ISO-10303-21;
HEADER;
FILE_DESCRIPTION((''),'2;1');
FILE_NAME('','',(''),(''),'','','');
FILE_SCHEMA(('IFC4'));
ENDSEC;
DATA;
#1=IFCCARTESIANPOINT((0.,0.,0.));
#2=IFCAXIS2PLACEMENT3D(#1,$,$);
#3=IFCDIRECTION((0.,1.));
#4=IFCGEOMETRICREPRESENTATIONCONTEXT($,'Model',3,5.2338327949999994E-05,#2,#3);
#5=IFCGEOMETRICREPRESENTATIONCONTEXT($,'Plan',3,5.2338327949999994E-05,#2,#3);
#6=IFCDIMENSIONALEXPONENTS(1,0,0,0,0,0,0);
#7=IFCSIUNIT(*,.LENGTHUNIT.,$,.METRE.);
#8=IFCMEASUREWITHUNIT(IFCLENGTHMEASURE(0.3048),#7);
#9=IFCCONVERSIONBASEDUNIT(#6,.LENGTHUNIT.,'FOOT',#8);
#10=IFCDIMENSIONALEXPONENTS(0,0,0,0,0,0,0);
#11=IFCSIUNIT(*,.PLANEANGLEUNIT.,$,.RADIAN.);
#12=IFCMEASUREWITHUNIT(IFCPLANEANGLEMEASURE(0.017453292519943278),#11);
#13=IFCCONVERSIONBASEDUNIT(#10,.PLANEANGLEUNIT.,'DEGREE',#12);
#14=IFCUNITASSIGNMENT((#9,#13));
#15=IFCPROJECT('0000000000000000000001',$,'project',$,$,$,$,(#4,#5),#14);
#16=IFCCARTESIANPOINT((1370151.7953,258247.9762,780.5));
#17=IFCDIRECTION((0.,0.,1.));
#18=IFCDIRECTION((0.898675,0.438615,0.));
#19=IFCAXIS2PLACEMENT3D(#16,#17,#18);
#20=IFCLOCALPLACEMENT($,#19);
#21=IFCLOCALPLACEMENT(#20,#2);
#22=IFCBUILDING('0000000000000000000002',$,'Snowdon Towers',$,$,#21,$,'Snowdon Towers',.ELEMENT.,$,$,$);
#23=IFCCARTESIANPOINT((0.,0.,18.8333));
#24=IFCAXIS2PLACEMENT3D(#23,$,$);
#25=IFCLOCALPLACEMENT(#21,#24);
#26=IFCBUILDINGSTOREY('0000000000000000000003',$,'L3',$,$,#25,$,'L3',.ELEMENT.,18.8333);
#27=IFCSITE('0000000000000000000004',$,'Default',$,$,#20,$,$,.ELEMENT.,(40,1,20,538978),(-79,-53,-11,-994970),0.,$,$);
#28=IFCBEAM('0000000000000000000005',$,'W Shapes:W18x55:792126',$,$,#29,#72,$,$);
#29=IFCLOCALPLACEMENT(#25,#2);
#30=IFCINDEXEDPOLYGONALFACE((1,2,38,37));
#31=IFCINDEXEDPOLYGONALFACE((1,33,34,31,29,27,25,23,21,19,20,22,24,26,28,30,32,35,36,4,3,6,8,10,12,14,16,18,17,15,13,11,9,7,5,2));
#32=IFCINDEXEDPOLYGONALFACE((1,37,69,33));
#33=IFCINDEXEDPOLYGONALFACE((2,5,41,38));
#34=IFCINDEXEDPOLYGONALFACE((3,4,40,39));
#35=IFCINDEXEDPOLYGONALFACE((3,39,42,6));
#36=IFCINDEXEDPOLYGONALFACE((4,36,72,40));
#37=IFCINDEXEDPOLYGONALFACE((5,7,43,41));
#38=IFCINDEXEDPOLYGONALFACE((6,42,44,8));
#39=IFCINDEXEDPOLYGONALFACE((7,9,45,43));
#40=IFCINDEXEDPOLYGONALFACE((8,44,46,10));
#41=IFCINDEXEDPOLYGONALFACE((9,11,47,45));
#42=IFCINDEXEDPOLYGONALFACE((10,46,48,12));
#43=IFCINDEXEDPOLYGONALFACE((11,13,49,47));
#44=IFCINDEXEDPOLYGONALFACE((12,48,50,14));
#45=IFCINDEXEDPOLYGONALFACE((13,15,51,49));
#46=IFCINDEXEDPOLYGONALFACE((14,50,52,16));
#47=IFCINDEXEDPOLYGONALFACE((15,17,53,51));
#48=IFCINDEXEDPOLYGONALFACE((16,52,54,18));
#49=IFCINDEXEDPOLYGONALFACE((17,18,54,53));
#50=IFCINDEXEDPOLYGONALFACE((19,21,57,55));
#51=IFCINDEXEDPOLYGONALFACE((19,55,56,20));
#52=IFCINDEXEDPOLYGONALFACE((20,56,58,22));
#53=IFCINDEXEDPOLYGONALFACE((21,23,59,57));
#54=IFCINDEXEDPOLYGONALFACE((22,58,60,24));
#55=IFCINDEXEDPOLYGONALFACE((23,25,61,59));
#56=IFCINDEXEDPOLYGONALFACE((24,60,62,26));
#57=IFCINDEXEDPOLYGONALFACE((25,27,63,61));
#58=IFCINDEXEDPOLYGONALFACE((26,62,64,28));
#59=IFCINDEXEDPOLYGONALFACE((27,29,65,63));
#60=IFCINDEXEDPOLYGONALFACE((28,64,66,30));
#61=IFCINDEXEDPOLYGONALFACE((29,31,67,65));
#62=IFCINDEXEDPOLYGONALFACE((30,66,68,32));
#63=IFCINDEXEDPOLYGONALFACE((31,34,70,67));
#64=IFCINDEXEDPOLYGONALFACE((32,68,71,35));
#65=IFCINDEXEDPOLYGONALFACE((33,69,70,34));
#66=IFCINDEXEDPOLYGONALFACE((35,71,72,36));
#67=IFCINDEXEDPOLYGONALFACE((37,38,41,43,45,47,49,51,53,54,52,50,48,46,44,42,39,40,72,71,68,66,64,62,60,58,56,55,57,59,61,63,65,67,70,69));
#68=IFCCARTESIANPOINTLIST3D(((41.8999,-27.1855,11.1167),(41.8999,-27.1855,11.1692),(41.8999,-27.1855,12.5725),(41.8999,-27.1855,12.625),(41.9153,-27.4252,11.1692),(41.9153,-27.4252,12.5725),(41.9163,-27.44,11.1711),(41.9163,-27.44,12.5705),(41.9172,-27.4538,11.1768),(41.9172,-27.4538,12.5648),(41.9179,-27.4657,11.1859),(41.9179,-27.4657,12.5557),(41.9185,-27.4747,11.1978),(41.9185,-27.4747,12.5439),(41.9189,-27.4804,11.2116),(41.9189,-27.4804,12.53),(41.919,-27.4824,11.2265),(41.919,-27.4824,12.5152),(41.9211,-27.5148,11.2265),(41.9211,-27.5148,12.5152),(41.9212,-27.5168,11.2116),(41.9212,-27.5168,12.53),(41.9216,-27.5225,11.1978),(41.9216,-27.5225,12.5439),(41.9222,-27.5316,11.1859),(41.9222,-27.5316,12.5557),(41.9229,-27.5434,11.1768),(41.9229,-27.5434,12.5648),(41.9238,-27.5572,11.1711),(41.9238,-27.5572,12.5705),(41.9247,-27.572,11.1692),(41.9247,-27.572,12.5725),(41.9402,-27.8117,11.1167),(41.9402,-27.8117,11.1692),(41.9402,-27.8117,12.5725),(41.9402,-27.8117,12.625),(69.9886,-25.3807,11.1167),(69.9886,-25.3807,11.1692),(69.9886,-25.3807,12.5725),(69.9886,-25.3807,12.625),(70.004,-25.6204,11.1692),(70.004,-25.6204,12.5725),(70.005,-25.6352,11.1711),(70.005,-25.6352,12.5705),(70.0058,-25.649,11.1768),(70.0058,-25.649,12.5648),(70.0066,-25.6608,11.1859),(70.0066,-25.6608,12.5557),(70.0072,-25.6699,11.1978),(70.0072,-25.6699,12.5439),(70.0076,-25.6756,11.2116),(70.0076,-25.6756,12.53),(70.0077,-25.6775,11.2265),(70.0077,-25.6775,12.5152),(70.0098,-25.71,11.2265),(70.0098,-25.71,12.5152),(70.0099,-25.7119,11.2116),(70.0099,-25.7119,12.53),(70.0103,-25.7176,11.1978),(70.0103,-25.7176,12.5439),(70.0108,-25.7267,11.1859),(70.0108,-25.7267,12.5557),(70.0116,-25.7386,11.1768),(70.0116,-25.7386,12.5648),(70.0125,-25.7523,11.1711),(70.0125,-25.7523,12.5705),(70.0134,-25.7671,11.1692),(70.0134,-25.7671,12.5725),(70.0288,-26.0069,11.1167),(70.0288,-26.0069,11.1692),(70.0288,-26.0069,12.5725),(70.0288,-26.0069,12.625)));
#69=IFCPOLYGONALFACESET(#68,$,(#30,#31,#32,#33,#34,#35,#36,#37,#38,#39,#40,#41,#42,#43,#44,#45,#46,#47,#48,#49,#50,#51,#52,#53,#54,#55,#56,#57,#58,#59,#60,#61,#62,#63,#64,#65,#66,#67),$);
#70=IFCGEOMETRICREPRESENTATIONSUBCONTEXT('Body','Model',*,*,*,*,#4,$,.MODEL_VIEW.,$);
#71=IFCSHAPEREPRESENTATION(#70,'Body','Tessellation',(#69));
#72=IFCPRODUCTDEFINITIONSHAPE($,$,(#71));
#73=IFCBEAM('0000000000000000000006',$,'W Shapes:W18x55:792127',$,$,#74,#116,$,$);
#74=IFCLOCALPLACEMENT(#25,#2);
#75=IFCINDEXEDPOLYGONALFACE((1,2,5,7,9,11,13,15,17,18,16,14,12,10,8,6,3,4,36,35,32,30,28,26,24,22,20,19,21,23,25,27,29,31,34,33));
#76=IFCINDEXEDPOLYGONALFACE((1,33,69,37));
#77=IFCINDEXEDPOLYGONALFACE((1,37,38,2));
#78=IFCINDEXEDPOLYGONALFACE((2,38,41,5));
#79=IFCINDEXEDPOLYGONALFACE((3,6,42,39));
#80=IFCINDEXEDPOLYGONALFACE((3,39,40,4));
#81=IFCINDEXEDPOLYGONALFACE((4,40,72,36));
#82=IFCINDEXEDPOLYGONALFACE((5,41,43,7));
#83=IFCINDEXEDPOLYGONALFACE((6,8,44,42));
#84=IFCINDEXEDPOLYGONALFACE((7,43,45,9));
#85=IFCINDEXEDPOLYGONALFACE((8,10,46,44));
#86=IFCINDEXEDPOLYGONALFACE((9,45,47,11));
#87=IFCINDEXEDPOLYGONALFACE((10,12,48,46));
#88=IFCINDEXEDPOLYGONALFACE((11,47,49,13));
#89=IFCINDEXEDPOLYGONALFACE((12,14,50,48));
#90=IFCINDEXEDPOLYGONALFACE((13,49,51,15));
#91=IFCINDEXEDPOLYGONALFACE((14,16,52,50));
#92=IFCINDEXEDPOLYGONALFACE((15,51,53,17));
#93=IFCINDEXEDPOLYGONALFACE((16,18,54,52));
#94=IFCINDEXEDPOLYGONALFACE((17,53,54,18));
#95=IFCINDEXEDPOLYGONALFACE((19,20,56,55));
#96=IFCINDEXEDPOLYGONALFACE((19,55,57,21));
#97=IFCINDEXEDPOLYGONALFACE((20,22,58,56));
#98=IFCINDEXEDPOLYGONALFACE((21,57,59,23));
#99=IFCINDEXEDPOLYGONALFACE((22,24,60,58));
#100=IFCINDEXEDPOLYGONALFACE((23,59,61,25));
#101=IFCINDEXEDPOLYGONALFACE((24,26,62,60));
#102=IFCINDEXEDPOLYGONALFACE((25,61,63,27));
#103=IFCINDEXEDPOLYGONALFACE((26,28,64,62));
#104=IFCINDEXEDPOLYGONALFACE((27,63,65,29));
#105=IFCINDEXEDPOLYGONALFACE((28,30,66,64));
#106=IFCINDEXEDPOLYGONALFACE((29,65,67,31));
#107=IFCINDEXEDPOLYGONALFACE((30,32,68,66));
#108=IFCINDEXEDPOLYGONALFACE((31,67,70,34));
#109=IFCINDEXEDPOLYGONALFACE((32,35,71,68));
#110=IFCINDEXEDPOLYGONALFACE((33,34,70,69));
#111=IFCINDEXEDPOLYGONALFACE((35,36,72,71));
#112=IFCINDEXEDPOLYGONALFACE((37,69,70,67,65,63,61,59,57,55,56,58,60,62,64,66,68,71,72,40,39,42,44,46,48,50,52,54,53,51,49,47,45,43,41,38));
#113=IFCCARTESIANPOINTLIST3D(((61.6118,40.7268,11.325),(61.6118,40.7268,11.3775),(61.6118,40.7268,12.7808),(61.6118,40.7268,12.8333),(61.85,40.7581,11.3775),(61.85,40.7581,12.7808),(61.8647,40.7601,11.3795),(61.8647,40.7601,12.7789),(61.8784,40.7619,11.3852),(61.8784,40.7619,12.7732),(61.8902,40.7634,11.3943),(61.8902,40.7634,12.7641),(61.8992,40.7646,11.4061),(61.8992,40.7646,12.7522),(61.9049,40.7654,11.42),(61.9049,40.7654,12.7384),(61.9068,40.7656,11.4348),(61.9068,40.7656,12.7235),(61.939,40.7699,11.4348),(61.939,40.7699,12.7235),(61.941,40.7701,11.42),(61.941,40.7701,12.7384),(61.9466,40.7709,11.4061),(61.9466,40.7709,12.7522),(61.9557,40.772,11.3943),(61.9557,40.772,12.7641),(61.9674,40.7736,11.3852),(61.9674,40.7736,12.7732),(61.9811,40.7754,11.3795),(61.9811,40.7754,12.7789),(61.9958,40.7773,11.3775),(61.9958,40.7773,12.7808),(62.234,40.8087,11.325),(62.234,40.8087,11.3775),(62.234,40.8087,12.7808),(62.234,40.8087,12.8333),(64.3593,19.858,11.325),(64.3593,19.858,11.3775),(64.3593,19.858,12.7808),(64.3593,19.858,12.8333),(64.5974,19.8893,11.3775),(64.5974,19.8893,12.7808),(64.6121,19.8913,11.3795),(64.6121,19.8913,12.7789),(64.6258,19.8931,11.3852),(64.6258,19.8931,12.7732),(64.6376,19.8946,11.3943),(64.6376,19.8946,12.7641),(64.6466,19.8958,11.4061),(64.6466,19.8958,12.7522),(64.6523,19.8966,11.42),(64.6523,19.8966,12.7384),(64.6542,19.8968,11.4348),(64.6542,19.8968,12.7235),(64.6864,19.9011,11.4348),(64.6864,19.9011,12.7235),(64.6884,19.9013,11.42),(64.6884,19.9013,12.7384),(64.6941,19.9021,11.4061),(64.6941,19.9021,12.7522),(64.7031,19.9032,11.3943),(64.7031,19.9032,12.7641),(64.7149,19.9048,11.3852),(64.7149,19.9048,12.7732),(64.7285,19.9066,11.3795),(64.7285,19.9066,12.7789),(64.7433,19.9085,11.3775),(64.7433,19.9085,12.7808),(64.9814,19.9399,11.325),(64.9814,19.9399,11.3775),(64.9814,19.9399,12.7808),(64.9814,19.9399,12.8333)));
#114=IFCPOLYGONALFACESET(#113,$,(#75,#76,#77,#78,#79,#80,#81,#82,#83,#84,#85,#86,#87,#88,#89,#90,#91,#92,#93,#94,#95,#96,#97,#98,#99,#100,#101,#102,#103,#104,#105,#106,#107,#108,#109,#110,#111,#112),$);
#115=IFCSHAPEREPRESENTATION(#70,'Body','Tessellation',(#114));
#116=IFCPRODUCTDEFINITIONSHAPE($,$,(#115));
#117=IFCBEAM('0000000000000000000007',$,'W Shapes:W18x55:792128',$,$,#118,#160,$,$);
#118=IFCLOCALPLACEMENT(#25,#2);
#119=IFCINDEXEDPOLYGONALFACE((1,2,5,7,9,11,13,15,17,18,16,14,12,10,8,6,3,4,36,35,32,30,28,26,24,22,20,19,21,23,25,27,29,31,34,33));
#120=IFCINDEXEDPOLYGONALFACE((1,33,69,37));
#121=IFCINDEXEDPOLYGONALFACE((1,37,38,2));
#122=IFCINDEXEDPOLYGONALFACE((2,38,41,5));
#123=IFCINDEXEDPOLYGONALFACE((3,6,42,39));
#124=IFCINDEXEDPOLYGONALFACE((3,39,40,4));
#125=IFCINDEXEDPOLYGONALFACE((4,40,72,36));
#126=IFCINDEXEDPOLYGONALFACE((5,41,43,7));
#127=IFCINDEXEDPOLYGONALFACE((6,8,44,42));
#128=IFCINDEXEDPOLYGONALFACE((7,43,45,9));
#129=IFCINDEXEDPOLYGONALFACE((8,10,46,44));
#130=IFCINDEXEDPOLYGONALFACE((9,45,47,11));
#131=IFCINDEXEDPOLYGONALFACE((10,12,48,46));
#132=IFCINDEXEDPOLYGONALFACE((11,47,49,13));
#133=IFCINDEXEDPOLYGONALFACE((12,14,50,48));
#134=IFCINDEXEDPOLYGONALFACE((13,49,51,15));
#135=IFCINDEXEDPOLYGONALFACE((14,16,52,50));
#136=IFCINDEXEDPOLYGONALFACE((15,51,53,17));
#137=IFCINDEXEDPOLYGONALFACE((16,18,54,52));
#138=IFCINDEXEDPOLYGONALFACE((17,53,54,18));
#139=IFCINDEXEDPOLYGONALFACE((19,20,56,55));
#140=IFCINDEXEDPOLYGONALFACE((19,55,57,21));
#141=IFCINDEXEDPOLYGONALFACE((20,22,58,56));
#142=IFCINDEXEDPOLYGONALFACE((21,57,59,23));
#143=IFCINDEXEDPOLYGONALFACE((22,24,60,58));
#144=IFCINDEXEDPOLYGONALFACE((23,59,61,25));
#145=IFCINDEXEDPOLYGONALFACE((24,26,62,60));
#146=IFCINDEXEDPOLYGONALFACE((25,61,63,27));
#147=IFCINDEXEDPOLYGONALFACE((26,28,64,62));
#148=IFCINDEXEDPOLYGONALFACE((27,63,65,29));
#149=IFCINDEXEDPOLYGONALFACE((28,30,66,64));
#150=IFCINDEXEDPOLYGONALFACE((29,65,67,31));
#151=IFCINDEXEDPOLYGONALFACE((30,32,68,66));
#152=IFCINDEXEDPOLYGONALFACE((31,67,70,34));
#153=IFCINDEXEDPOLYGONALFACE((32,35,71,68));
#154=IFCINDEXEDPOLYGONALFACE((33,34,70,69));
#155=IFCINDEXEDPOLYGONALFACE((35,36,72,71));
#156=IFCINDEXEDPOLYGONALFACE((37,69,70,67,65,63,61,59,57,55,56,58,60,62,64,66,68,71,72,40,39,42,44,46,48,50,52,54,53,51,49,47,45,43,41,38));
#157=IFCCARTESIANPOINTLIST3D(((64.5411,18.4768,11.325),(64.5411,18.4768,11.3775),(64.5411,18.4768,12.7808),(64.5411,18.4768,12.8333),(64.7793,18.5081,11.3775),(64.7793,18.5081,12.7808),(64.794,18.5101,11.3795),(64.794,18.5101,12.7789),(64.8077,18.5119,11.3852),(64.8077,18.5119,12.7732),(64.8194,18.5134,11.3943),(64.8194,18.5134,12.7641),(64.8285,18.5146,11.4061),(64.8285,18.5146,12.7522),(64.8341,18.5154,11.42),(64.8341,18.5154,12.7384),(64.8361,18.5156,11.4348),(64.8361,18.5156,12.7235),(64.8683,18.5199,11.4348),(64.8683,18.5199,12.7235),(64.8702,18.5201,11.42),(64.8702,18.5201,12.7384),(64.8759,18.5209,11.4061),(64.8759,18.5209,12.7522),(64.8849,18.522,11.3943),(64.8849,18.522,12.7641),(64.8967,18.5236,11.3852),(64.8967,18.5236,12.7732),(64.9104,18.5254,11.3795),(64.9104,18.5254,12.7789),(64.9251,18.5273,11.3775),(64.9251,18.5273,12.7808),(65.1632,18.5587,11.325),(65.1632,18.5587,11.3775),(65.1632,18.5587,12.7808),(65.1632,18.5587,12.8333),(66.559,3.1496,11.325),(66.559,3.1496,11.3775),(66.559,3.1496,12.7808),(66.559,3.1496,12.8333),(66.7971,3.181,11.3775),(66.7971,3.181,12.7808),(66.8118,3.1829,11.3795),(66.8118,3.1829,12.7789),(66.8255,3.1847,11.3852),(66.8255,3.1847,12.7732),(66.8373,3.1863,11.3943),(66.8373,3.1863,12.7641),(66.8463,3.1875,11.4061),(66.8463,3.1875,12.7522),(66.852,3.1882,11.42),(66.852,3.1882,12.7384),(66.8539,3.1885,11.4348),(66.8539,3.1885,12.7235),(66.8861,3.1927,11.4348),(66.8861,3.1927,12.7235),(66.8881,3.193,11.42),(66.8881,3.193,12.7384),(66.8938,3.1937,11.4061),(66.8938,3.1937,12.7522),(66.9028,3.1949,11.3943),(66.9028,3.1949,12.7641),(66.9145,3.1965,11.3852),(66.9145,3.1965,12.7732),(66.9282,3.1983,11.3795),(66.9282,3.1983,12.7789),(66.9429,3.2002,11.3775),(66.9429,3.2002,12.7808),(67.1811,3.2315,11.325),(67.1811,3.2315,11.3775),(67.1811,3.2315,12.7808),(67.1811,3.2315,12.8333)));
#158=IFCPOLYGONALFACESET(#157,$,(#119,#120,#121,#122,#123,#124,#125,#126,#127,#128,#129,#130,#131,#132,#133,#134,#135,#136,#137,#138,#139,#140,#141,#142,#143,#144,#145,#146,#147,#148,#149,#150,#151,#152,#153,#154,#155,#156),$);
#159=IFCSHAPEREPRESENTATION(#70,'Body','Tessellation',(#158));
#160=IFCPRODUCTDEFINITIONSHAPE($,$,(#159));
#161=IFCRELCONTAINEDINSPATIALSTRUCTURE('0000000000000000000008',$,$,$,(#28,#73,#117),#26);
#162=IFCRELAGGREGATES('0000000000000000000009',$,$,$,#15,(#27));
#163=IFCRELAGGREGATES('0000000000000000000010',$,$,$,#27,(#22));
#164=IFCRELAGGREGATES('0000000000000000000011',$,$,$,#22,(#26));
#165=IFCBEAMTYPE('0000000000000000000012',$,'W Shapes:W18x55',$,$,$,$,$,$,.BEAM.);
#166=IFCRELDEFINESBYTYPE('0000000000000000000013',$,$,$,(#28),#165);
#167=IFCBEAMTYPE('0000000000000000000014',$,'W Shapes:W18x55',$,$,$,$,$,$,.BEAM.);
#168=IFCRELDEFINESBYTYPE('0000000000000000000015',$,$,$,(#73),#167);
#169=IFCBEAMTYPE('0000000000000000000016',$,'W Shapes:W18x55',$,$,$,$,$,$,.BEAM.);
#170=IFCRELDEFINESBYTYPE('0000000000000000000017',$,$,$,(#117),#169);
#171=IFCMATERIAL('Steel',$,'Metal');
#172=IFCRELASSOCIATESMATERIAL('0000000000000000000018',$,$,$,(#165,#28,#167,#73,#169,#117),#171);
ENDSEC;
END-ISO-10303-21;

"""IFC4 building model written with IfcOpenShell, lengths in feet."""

from ifc_helpers import new_model, entity, si_unit, converted_unit, direction, frame, origin, place, context, subcontext, project, spatial, line, arc, indexed_curve, outline, extrude, source, transform, mapped, material, type_object, type_shapes, element, save


model = new_model("IFC4")

# Units and contexts
model_context = context("Model", 3, precision=5.2338327949999994e-05, world=origin(), true_north=direction((0.0, 1.0)))
plan_context = context("Plan", 3, precision=5.2338327949999994e-05, world=origin(), true_north=direction((0.0, 1.0)))
body_context = subcontext(model_context, "Body", "Model", "MODEL_VIEW")
ifc_project = project(units=[converted_unit("LENGTHUNIT", "FOOT", entity("IfcLengthMeasure", 0.3048), si_unit("LENGTHUNIT", "METRE"), dimensions=[1, 0, 0, 0, 0, 0, 0]), converted_unit("PLANEANGLEUNIT", "DEGREE", entity("IfcPlaneAngleMeasure", 0.017453292519943278), si_unit("PLANEANGLEUNIT", "RADIAN"), dimensions=[0, 0, 0, 0, 0, 0, 0])], contexts=[model_context, plan_context])

# Site, building, storey
site_placement = place(None, frame((1370151.7953, 258247.9762, 780.5), z_axis=(0.0, 0.0, 1.0), x_axis=(0.898675, 0.438615, 0.0)))
site = spatial("IfcSite", under=ifc_project, at=site_placement, Name="Default", CompositionType="ELEMENT", RefLatitude=(40, 1, 20, 538978), RefLongitude=(-79, -53, -11, -994970), RefElevation=0.0)
building_placement = place(site_placement, origin())
building = spatial("IfcBuilding", under=site, at=building_placement, Name="Snowdon Towers", LongName="Snowdon Towers", CompositionType="ELEMENT")
storey_placement = place(building_placement, frame((0.0, 0.0, 18.8333)))
storey = spatial("IfcBuildingStorey", under=building, at=storey_placement, Name="L3", LongName="L3", CompositionType="ELEMENT", Elevation=18.8333)

# Beams
ifc_material_1 = material(Name="Steel", Category="Metal")
beam_type_1 = type_object("IfcBeamType", Name="W Shapes:W18x55", PredefinedType="BEAM", material=ifc_material_1)
shared_shape_1 = source(origin(), body_context, "Body", "SweptSolid", [
    extrude(outline(indexed_curve([(-0.7542, -0.3137), (-0.7017, -0.3137), (-0.7017, -0.0735), (-0.6849, -0.033), (-0.6444, -0.0162), (0.6444, -0.0163), (0.6849, -0.033), (0.7017, -0.0735), (0.7017, -0.3138), (0.7542, -0.3138), (0.7542, 0.3137), (0.7017, 0.3137), (0.7017, 0.0735), (0.6849, 0.033), (0.6444, 0.0162), (-0.6444, 0.0163), (-0.6849, 0.033), (-0.7017, 0.0735), (-0.7017, 0.3138), (-0.7542, 0.3138)], segments=[line(1, 2, 3), arc(3, 4, 5), line(5, 6), arc(6, 7, 8), line(8, 9, 10, 11, 12, 13), arc(13, 14, 15), line(15, 16), arc(16, 17, 18), line(18, 19, 20, 1)], self_intersect=False)), frame((-14.3614, 0.0, 0.0), z_axis=(1.0, 0.0, 0.0), x_axis=(0.0, 0.0, -1.0)), (0.0, 0.0, 1.0), 28.1466),
])
type_shapes(beam_type_1, [shared_shape_1])
beam_1_placement = place(storey_placement, frame((56.2518, -26.5777, 11.8708), z_axis=(0.0, 0.0, 1.0), x_axis=(0.997942, 0.064123, 0.0)))
element("IfcBeam", 1, at=beam_1_placement, inside=storey, type_object=beam_type_1, material=ifc_material_1, Name="W Shapes:W18x55:792126", context=body_context, shape_type="MappedRepresentation", body=[
    mapped(shared_shape_1, transform((0.0, 0.0, 0.0), scale=1.0)),
])
beam_type_2 = type_object("IfcBeamType", Name="W Shapes:W18x55", PredefinedType="BEAM", material=ifc_material_1)
shared_shape_2 = source(origin(), body_context, "Body", "SweptSolid", [
    extrude(outline(indexed_curve([(-0.7542, -0.3138), (-0.7017, -0.3138), (-0.7017, -0.0735), (-0.6849, -0.033), (-0.6444, -0.0162), (0.6444, -0.0162), (0.6849, -0.033), (0.7017, -0.0735), (0.7017, -0.3138), (0.7542, -0.3138), (0.7542, 0.3138), (0.7017, 0.3138), (0.7017, 0.0735), (0.6849, 0.033), (0.6444, 0.0163), (-0.6444, 0.0163), (-0.6849, 0.033), (-0.7017, 0.0735), (-0.7017, 0.3137), (-0.7542, 0.3137)], segments=[line(1, 2, 3), arc(3, 4, 5), line(5, 6), arc(6, 7, 8), line(8, 9, 10, 11, 12, 13), arc(13, 14, 15), line(15, 16), arc(16, 17, 18), line(18, 19, 20, 1)], self_intersect=False)), frame((-10.5172, 0.0, 0.0), z_axis=(1.0, 0.0, 0.0), x_axis=(0.0, 0.0, -1.0)), (0.0, 0.0, 1.0), 21.0489),
])
type_shapes(beam_type_2, [shared_shape_2])
beam_2_placement = place(storey_placement, frame((63.2957, 30.3405, 12.0792), z_axis=(0.0, 0.0, 1.0), x_axis=(0.130526, -0.991445, 0.0)))
element("IfcBeam", 2, at=beam_2_placement, inside=storey, type_object=beam_type_2, material=ifc_material_1, Name="W Shapes:W18x55:792127", context=body_context, shape_type="MappedRepresentation", body=[
    mapped(shared_shape_2, transform((0.0, 0.0, 0.0), scale=1.0)),
])
beam_type_3 = type_object("IfcBeamType", Name="W Shapes:W18x55", PredefinedType="BEAM", material=ifc_material_1)
shared_shape_3 = source(origin(), body_context, "Body", "SweptSolid", [
    extrude(outline(indexed_curve([(-0.7542, -0.3138), (-0.7017, -0.3138), (-0.7017, -0.0735), (-0.6849, -0.033), (-0.6444, -0.0162), (0.6444, -0.0162), (0.6849, -0.033), (0.7017, -0.0735), (0.7017, -0.3138), (0.7542, -0.3138), (0.7542, 0.3138), (0.7017, 0.3138), (0.7017, 0.0735), (0.6849, 0.033), (0.6444, 0.0163), (-0.6444, 0.0163), (-0.6849, 0.033), (-0.7017, 0.0735), (-0.7017, 0.3137), (-0.7542, 0.3137)], segments=[line(1, 2, 3), arc(3, 4, 5), line(5, 6), arc(6, 7, 8), line(8, 9, 10, 11, 12, 13), arc(13, 14, 15), line(15, 16), arc(16, 17, 18), line(18, 19, 20, 1)], self_intersect=False)), frame((-7.8065, 0.0, 0.0), z_axis=(1.0, 0.0, 0.0), x_axis=(0.0, 0.0, -1.0)), (0.0, 0.0, 1.0), 15.4594),
])
type_shapes(beam_type_3, [shared_shape_3])
beam_3_placement = place(storey_placement, frame((65.8711, 10.778, 12.0792), z_axis=(0.0, 0.0, 1.0), x_axis=(0.130526, -0.991445, 0.0)))
element("IfcBeam", 3, at=beam_3_placement, inside=storey, type_object=beam_type_3, material=ifc_material_1, Name="W Shapes:W18x55:792128", context=body_context, shape_type="MappedRepresentation", body=[
    mapped(shared_shape_3, transform((0.0, 0.0, 0.0), scale=1.0)),
])

save(model, "model.ifc")
